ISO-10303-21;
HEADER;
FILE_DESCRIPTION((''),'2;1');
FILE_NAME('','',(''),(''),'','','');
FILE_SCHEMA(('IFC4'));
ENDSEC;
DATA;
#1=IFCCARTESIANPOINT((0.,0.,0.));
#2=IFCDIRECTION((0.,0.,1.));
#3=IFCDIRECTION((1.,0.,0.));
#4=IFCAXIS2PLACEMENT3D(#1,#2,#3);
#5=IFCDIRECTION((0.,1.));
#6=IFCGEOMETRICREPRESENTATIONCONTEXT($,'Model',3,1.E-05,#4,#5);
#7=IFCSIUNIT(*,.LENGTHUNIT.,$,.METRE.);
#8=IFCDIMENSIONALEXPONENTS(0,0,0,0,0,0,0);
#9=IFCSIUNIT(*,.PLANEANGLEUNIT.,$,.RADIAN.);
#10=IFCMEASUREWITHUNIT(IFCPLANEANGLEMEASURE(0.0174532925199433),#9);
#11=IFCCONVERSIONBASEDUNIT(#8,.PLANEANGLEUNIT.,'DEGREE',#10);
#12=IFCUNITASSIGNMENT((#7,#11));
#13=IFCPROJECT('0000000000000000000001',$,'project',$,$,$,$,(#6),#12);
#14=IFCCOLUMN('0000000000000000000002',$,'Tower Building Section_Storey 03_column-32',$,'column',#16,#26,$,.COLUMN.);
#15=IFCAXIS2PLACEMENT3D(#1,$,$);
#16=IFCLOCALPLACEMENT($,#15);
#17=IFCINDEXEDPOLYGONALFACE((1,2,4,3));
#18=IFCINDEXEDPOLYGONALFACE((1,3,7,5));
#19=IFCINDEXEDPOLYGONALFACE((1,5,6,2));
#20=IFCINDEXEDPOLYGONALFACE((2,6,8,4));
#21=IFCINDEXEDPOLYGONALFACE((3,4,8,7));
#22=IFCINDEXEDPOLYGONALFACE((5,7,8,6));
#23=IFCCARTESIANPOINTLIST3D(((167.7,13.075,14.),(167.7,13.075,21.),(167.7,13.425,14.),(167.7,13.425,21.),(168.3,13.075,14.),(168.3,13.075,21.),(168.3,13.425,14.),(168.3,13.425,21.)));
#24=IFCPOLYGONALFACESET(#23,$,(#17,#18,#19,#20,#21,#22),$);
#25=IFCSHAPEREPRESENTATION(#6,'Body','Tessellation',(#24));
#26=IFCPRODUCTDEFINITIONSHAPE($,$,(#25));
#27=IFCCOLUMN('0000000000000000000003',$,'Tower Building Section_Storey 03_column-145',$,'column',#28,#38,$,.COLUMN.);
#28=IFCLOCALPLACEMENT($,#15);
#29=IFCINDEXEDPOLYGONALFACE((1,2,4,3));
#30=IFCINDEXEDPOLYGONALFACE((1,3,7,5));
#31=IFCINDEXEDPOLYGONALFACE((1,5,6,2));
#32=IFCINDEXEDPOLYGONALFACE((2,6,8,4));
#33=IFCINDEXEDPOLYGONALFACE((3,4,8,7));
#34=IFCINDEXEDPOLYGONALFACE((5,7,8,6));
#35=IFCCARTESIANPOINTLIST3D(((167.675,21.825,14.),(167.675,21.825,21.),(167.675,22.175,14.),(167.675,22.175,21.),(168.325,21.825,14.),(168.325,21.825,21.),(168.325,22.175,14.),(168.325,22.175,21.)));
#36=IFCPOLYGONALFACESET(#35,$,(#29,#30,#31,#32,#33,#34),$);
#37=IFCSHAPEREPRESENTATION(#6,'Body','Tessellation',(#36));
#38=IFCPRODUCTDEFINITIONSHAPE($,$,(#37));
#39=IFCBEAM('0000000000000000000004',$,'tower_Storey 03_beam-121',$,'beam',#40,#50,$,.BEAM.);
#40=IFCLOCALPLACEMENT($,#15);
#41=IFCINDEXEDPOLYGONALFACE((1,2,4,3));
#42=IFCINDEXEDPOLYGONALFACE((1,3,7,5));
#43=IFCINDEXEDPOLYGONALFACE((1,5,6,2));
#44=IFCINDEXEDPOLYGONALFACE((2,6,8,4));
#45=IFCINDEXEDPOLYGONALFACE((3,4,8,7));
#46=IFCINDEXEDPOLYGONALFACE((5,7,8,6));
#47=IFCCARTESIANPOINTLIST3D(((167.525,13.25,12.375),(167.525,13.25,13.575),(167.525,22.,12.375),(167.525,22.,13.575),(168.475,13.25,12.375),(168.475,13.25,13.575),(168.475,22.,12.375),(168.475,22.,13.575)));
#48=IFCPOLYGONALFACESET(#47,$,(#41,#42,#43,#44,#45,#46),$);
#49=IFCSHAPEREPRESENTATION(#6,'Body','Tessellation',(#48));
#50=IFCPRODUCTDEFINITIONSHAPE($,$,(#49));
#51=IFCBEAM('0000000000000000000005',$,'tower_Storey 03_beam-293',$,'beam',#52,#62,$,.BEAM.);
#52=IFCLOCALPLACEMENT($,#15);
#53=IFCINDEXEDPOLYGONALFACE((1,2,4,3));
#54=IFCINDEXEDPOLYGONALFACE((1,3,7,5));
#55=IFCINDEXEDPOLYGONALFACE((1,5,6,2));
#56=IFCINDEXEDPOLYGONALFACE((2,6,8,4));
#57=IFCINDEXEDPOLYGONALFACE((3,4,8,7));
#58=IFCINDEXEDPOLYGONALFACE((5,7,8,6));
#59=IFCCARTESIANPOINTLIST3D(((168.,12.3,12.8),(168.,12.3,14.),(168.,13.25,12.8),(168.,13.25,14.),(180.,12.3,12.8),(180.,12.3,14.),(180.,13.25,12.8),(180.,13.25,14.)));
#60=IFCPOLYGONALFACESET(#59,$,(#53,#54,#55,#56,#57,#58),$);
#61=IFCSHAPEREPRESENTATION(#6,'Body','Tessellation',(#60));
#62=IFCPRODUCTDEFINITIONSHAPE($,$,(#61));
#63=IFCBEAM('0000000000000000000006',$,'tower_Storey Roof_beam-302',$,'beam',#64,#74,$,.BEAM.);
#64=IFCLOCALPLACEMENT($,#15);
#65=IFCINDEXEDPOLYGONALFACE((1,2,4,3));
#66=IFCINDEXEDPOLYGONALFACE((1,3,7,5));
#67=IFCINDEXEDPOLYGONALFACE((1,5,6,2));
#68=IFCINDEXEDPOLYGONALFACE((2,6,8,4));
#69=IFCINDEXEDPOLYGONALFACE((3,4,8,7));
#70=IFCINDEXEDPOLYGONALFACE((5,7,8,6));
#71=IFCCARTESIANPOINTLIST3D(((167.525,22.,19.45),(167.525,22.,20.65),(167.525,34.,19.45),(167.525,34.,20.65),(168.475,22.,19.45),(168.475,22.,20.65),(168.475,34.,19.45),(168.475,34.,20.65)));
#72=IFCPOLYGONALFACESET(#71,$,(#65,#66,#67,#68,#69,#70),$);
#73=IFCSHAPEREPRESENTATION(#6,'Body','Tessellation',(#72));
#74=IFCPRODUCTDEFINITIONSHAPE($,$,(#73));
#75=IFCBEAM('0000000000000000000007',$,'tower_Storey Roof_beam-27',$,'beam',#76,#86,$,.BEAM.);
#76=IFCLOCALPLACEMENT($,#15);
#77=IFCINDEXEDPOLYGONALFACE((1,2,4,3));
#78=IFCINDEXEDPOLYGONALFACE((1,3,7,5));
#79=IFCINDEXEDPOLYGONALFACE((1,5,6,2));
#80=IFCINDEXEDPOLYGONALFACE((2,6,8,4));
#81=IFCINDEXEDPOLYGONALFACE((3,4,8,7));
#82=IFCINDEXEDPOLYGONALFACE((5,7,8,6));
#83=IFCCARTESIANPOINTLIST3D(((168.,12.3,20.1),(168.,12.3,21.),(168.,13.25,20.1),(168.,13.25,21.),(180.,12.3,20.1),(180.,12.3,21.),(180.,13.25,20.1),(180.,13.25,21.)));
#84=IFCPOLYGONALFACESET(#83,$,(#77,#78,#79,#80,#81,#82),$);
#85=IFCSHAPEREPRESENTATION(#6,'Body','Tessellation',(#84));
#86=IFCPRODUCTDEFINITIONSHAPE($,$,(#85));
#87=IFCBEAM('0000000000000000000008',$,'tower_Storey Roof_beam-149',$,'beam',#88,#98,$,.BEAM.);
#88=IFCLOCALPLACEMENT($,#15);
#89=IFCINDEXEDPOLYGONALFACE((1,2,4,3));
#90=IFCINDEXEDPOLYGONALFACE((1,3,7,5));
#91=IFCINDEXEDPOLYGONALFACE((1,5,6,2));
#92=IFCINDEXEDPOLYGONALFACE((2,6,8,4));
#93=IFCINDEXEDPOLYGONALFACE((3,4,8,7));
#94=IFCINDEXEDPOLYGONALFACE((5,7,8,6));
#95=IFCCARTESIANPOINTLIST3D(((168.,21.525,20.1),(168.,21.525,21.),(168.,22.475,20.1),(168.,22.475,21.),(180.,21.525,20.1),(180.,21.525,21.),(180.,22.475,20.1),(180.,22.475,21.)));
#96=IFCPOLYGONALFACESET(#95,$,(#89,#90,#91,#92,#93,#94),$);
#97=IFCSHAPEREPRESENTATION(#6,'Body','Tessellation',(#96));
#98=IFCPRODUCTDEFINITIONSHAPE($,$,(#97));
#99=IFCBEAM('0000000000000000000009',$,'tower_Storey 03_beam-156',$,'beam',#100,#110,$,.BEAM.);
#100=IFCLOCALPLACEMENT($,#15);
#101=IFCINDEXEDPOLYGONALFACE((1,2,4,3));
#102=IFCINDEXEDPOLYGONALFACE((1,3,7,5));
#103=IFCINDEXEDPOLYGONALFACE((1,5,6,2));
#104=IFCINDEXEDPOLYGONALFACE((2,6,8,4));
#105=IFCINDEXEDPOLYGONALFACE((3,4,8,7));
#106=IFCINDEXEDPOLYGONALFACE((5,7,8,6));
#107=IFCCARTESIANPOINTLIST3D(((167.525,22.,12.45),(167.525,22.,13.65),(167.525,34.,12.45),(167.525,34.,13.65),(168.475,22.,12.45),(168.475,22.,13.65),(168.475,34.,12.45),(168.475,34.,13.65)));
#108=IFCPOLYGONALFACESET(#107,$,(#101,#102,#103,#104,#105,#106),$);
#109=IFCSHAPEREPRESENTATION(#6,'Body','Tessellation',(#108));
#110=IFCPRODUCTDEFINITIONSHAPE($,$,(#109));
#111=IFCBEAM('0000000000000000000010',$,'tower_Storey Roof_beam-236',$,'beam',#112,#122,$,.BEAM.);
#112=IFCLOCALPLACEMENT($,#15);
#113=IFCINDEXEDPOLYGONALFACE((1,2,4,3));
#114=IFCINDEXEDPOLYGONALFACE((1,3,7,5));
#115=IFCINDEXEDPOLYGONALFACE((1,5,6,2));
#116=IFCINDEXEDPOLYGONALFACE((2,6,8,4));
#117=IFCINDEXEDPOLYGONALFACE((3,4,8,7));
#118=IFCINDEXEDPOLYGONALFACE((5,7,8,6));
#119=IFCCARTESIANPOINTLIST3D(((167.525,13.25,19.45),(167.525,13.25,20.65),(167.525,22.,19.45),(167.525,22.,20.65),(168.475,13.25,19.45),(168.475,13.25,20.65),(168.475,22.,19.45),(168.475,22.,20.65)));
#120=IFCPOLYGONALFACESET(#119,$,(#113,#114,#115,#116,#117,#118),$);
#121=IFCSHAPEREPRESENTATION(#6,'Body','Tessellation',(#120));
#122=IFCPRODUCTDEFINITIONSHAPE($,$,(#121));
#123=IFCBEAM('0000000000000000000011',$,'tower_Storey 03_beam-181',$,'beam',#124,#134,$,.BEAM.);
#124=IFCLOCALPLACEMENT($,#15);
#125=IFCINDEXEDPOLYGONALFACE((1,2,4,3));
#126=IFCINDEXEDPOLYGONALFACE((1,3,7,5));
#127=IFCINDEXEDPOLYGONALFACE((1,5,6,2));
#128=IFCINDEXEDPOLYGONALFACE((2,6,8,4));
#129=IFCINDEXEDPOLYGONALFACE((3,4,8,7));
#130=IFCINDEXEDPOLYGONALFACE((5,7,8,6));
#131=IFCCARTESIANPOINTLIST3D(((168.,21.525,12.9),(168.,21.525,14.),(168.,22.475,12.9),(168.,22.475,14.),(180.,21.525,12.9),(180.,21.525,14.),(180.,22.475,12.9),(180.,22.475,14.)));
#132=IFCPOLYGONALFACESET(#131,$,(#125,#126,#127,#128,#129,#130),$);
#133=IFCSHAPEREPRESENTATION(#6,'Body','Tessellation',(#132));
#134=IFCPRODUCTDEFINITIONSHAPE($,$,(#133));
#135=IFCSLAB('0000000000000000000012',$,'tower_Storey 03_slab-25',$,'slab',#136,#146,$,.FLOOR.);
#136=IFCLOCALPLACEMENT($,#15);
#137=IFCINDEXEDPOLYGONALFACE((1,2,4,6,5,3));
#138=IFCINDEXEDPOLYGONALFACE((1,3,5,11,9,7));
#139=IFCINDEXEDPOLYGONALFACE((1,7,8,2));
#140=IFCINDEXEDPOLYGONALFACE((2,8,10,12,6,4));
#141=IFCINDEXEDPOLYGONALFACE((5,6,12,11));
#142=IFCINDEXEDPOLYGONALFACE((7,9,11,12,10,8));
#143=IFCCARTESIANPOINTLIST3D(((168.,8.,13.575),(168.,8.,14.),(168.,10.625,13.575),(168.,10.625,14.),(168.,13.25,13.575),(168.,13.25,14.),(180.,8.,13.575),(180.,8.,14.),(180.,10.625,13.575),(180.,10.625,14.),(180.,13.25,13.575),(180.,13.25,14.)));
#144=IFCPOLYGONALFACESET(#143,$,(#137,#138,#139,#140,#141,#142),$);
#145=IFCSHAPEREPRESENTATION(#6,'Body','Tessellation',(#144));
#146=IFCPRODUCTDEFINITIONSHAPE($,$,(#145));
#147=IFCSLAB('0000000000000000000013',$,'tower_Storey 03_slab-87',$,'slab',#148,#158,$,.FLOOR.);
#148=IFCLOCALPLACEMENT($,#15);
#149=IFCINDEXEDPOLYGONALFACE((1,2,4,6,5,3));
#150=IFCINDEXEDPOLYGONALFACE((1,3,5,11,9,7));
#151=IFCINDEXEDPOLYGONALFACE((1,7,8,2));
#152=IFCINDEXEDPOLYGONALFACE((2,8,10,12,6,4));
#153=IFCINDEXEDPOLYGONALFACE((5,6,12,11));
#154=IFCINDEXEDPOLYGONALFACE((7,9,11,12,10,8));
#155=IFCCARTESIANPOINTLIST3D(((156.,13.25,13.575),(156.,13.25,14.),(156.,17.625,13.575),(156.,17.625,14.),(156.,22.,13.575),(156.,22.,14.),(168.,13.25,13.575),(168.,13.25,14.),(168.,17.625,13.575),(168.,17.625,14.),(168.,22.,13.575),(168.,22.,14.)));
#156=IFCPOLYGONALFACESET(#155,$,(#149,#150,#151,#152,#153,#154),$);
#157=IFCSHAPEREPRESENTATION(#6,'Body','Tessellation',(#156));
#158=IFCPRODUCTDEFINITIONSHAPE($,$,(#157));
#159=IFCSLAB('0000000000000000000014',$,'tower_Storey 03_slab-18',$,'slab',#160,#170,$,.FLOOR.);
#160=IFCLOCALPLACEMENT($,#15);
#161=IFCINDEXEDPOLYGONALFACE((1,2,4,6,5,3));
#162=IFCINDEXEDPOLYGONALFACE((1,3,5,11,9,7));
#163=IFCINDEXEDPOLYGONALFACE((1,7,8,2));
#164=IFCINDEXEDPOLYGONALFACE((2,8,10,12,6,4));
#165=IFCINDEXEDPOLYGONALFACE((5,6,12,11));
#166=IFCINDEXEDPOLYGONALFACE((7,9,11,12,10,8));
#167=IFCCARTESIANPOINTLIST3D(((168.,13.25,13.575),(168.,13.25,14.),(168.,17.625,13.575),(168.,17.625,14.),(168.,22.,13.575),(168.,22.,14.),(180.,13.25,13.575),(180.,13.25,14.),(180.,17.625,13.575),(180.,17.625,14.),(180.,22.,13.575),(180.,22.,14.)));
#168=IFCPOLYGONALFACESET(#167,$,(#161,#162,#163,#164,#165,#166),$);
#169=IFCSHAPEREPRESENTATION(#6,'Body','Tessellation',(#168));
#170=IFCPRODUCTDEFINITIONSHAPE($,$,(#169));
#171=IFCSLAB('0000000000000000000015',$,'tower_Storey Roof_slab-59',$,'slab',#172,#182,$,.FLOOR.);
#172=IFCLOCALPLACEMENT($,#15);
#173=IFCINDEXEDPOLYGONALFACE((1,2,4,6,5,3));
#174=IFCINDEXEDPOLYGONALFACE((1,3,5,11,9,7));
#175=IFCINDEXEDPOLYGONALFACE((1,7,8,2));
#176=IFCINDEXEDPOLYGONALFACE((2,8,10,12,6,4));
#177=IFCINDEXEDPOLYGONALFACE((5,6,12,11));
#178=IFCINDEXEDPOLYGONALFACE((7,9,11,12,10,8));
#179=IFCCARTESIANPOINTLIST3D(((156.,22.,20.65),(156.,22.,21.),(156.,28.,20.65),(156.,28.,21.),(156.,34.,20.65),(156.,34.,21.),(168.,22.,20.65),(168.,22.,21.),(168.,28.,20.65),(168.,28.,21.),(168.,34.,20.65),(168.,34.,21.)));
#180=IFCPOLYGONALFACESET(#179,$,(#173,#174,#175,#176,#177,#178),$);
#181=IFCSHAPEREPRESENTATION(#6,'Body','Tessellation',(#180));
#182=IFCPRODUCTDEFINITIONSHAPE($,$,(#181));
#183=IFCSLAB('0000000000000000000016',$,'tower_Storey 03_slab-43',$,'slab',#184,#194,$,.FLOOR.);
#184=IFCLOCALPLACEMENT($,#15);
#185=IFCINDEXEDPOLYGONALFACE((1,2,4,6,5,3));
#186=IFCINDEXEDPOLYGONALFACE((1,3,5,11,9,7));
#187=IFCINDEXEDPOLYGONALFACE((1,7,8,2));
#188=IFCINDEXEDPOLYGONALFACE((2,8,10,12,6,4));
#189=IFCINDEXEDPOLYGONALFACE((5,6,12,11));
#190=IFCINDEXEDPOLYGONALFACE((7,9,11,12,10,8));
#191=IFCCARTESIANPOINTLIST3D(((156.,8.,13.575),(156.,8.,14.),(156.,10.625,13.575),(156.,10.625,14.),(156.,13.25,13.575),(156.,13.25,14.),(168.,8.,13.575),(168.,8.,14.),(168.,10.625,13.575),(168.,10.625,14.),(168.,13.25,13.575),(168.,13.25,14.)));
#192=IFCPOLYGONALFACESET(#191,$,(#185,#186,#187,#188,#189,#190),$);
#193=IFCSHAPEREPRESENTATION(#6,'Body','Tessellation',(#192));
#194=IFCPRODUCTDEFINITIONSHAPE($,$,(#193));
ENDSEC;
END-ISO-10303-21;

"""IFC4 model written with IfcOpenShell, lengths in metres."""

from ifc_helpers import new_model, entity, si_unit, converted_unit, direction, frame, origin_with_axes, place, context, project, polyline, outline, extrude, element, save


model = new_model("IFC4")

# Units and contexts
model_context = context("Model", 3, precision=1e-05, world=origin_with_axes(), true_north=direction((0.0, 1.0)))
ifc_project = project(units=[si_unit("LENGTHUNIT", "METRE"), converted_unit("PLANEANGLEUNIT", "DEGREE", entity("IfcPlaneAngleMeasure", 0.0174532925199433), si_unit("PLANEANGLEUNIT", "RADIAN"), dimensions=[0, 0, 0, 0, 0, 0, 0])], contexts=[model_context])

# Columns
placement_1 = place(None, origin_with_axes())
placement_2 = place(placement_1, frame((0.0, 0.0, 14.0), z_axis=(0.0, 0.0, 1.0), x_axis=(1.0, 0.0, 0.0)))
column_1_placement = place(placement_2, frame((168.0, 13.25, 0.0), z_axis=(0.0, 0.0, 1.0), x_axis=(1.0, 0.0, 0.0)))
element("IfcColumn", 1, at=column_1_placement, Name="Tower Building Section_Storey 03_column-32", ObjectType="column", PredefinedType="COLUMN", context=model_context, body=[
    extrude(outline(polyline([(-0.3, -0.175, 0.0), (0.3, -0.175, 0.0), (0.3, 0.175, 0.0), (-0.3, 0.175, 0.0), (-0.3, -0.175, 0.0)])), origin_with_axes(), (0.0, 0.0, 1.0), 7.0),
])
column_2_placement = place(placement_2, frame((168.0, 22.0, 0.0), z_axis=(0.0, 0.0, 1.0), x_axis=(1.0, 0.0, 0.0)))
element("IfcColumn", 2, at=column_2_placement, Name="Tower Building Section_Storey 03_column-145", ObjectType="column", PredefinedType="COLUMN", context=model_context, body=[
    extrude(outline(polyline([(-0.325, -0.175, 0.0), (0.325, -0.175, 0.0), (0.325, 0.175, 0.0), (-0.325, 0.175, 0.0), (-0.325, -0.175, 0.0)])), origin_with_axes(), (0.0, 0.0, 1.0), 7.0),
])

# Beams
beam_1_placement = place(placement_2, frame((168.0, 13.25, -1.025), z_axis=(0.0, 1.0, 0.0), x_axis=(-1.0, 0.0, 0.0)))
element("IfcBeam", 3, at=beam_1_placement, Name="tower_Storey 03_beam-121", ObjectType="beam", PredefinedType="BEAM", context=model_context, body=[
    extrude(outline(polyline([(0.475, 0.6, 0.0), (-0.475, 0.6, 0.0), (-0.475, -0.6, 0.0), (0.475, -0.6, 0.0), (0.475, 0.6, 0.0)])), origin_with_axes(), (0.0, 0.0, 1.0), 8.75),
])
beam_2_placement = place(placement_2, frame((168.0, 12.775, -0.6), z_axis=(1.0, 0.0, 0.0), x_axis=(0.0, 1.0, 0.0)))
element("IfcBeam", 4, at=beam_2_placement, Name="tower_Storey 03_beam-293", ObjectType="beam", PredefinedType="BEAM", context=model_context, body=[
    extrude(outline(polyline([(0.475, 0.6, 0.0), (-0.475, 0.6, 0.0), (-0.475, -0.6, 0.0), (0.475, -0.6, 0.0), (0.475, 0.6, 0.0)])), origin_with_axes(), (0.0, 0.0, 1.0), 12.0),
])
placement_3 = place(placement_1, frame((0.0, 0.0, 21.0), z_axis=(0.0, 0.0, 1.0), x_axis=(1.0, 0.0, 0.0)))
beam_3_placement = place(placement_3, frame((168.0, 22.0, -0.95), z_axis=(0.0, 1.0, 0.0), x_axis=(-1.0, 0.0, 0.0)))
element("IfcBeam", 5, at=beam_3_placement, Name="tower_Storey Roof_beam-302", ObjectType="beam", PredefinedType="BEAM", context=model_context, body=[
    extrude(outline(polyline([(0.475, 0.6, 0.0), (-0.475, 0.6, 0.0), (-0.475, -0.6, 0.0), (0.475, -0.6, 0.0), (0.475, 0.6, 0.0)])), origin_with_axes(), (0.0, 0.0, 1.0), 12.0),
])
for number, where, z_axis, x_axis, name in (
    (6, (168.0, 12.775, -0.45), (1.0, 0.0, 0.0), (0.0, 1.0, 0.0), "tower_Storey Roof_beam-27"),
    (7, (168.0, 22.0, -0.45), (1.0, 0.0, 0.0), (0.0, 1.0, 0.0), "tower_Storey Roof_beam-149"),
):
    element("IfcBeam", number, at=place(placement_3, frame(where, z_axis=z_axis, x_axis=x_axis)), Name=name, ObjectType="beam", PredefinedType="BEAM", context=model_context, body=[
        extrude(outline(polyline([(0.475, 0.45, 0.0), (-0.475, 0.45, 0.0), (-0.475, -0.45, 0.0), (0.475, -0.45, 0.0), (0.475, 0.45, 0.0)])), origin_with_axes(), (0.0, 0.0, 1.0), 12.0),
    ])
beam_4_placement = place(placement_2, frame((168.0, 22.0, -0.95), z_axis=(0.0, 1.0, 0.0), x_axis=(-1.0, 0.0, 0.0)))
element("IfcBeam", 8, at=beam_4_placement, Name="tower_Storey 03_beam-156", ObjectType="beam", PredefinedType="BEAM", context=model_context, body=[
    extrude(outline(polyline([(0.475, 0.6, 0.0), (-0.475, 0.6, 0.0), (-0.475, -0.6, 0.0), (0.475, -0.6, 0.0), (0.475, 0.6, 0.0)])), origin_with_axes(), (0.0, 0.0, 1.0), 12.0),
])
beam_5_placement = place(placement_3, frame((168.0, 13.25, -0.95), z_axis=(0.0, 1.0, 0.0), x_axis=(-1.0, 0.0, 0.0)))
element("IfcBeam", 9, at=beam_5_placement, Name="tower_Storey Roof_beam-236", ObjectType="beam", PredefinedType="BEAM", context=model_context, body=[
    extrude(outline(polyline([(0.475, 0.6, 0.0), (-0.475, 0.6, 0.0), (-0.475, -0.6, 0.0), (0.475, -0.6, 0.0), (0.475, 0.6, 0.0)])), origin_with_axes(), (0.0, 0.0, 1.0), 8.75),
])
beam_6_placement = place(placement_2, frame((168.0, 22.0, -0.55), z_axis=(1.0, 0.0, 0.0), x_axis=(0.0, 1.0, 0.0)))
element("IfcBeam", 10, at=beam_6_placement, Name="tower_Storey 03_beam-181", ObjectType="beam", PredefinedType="BEAM", context=model_context, body=[
    extrude(outline(polyline([(0.475, 0.55, 0.0), (-0.475, 0.55, 0.0), (-0.475, -0.55, 0.0), (0.475, -0.55, 0.0), (0.475, 0.55, 0.0)])), origin_with_axes(), (0.0, 0.0, 1.0), 12.0),
])

# Slabs
slab_1_placement = place(placement_2, frame((174.0, 10.625, -0.425), z_axis=(0.0, 0.0, 1.0), x_axis=(1.0, 0.0, 0.0)))
element("IfcSlab", 11, at=slab_1_placement, Name="tower_Storey 03_slab-25", ObjectType="slab", PredefinedType="FLOOR", context=model_context, body=[
    extrude(outline(polyline([(-6.0, -2.625, 0.0), (6.0, -2.625, 0.0), (6.0, 0.0, 0.0), (6.0, 2.625, 0.0), (-6.0, 2.625, 0.0), (-6.0, 0.0, 0.0), (-6.0, -2.625, 0.0)])), origin_with_axes(), (0.0, 0.0, 1.0), 0.425),
])
for number, where, z_axis, x_axis, name in (
    (12, (162.0, 17.625, -0.425), (0.0, 0.0, 1.0), (1.0, 0.0, 0.0), "tower_Storey 03_slab-87"),
    (13, (174.0, 17.625, -0.425), (0.0, 0.0, 1.0), (1.0, 0.0, 0.0), "tower_Storey 03_slab-18"),
):
    element("IfcSlab", number, at=place(placement_2, frame(where, z_axis=z_axis, x_axis=x_axis)), Name=name, ObjectType="slab", PredefinedType="FLOOR", context=model_context, body=[
        extrude(outline(polyline([(-6.0, 0.0, 0.0), (-6.0, -4.375, 0.0), (6.0, -4.375, 0.0), (6.0, 0.0, 0.0), (6.0, 4.375, 0.0), (-6.0, 4.375, 0.0), (-6.0, 0.0, 0.0)])), origin_with_axes(), (0.0, 0.0, 1.0), 0.425),
    ])
slab_2_placement = place(placement_3, frame((162.0, 28.0, -0.35), z_axis=(0.0, 0.0, 1.0), x_axis=(1.0, 0.0, 0.0)))
element("IfcSlab", 14, at=slab_2_placement, Name="tower_Storey Roof_slab-59", ObjectType="slab", PredefinedType="FLOOR", context=model_context, body=[
    extrude(outline(polyline([(-6.0, -6.0, 0.0), (6.0, -6.0, 0.0), (6.0, 0.0, 0.0), (6.0, 6.0, 0.0), (-6.0, 6.0, 0.0), (-6.0, 0.0, 0.0), (-6.0, -6.0, 0.0)])), origin_with_axes(), (0.0, 0.0, 1.0), 0.35),
])
slab_3_placement = place(placement_2, frame((162.0, 10.625, -0.425), z_axis=(0.0, 0.0, 1.0), x_axis=(1.0, 0.0, 0.0)))
element("IfcSlab", 15, at=slab_3_placement, Name="tower_Storey 03_slab-43", ObjectType="slab", PredefinedType="FLOOR", context=model_context, body=[
    extrude(outline(polyline([(-6.0, -2.625, 0.0), (6.0, -2.625, 0.0), (6.0, 0.0, 0.0), (6.0, 2.625, 0.0), (-6.0, 2.625, 0.0), (-6.0, 0.0, 0.0), (-6.0, -2.625, 0.0)])), origin_with_axes(), (0.0, 0.0, 1.0), 0.425),
])

save(model, "model.ifc")
